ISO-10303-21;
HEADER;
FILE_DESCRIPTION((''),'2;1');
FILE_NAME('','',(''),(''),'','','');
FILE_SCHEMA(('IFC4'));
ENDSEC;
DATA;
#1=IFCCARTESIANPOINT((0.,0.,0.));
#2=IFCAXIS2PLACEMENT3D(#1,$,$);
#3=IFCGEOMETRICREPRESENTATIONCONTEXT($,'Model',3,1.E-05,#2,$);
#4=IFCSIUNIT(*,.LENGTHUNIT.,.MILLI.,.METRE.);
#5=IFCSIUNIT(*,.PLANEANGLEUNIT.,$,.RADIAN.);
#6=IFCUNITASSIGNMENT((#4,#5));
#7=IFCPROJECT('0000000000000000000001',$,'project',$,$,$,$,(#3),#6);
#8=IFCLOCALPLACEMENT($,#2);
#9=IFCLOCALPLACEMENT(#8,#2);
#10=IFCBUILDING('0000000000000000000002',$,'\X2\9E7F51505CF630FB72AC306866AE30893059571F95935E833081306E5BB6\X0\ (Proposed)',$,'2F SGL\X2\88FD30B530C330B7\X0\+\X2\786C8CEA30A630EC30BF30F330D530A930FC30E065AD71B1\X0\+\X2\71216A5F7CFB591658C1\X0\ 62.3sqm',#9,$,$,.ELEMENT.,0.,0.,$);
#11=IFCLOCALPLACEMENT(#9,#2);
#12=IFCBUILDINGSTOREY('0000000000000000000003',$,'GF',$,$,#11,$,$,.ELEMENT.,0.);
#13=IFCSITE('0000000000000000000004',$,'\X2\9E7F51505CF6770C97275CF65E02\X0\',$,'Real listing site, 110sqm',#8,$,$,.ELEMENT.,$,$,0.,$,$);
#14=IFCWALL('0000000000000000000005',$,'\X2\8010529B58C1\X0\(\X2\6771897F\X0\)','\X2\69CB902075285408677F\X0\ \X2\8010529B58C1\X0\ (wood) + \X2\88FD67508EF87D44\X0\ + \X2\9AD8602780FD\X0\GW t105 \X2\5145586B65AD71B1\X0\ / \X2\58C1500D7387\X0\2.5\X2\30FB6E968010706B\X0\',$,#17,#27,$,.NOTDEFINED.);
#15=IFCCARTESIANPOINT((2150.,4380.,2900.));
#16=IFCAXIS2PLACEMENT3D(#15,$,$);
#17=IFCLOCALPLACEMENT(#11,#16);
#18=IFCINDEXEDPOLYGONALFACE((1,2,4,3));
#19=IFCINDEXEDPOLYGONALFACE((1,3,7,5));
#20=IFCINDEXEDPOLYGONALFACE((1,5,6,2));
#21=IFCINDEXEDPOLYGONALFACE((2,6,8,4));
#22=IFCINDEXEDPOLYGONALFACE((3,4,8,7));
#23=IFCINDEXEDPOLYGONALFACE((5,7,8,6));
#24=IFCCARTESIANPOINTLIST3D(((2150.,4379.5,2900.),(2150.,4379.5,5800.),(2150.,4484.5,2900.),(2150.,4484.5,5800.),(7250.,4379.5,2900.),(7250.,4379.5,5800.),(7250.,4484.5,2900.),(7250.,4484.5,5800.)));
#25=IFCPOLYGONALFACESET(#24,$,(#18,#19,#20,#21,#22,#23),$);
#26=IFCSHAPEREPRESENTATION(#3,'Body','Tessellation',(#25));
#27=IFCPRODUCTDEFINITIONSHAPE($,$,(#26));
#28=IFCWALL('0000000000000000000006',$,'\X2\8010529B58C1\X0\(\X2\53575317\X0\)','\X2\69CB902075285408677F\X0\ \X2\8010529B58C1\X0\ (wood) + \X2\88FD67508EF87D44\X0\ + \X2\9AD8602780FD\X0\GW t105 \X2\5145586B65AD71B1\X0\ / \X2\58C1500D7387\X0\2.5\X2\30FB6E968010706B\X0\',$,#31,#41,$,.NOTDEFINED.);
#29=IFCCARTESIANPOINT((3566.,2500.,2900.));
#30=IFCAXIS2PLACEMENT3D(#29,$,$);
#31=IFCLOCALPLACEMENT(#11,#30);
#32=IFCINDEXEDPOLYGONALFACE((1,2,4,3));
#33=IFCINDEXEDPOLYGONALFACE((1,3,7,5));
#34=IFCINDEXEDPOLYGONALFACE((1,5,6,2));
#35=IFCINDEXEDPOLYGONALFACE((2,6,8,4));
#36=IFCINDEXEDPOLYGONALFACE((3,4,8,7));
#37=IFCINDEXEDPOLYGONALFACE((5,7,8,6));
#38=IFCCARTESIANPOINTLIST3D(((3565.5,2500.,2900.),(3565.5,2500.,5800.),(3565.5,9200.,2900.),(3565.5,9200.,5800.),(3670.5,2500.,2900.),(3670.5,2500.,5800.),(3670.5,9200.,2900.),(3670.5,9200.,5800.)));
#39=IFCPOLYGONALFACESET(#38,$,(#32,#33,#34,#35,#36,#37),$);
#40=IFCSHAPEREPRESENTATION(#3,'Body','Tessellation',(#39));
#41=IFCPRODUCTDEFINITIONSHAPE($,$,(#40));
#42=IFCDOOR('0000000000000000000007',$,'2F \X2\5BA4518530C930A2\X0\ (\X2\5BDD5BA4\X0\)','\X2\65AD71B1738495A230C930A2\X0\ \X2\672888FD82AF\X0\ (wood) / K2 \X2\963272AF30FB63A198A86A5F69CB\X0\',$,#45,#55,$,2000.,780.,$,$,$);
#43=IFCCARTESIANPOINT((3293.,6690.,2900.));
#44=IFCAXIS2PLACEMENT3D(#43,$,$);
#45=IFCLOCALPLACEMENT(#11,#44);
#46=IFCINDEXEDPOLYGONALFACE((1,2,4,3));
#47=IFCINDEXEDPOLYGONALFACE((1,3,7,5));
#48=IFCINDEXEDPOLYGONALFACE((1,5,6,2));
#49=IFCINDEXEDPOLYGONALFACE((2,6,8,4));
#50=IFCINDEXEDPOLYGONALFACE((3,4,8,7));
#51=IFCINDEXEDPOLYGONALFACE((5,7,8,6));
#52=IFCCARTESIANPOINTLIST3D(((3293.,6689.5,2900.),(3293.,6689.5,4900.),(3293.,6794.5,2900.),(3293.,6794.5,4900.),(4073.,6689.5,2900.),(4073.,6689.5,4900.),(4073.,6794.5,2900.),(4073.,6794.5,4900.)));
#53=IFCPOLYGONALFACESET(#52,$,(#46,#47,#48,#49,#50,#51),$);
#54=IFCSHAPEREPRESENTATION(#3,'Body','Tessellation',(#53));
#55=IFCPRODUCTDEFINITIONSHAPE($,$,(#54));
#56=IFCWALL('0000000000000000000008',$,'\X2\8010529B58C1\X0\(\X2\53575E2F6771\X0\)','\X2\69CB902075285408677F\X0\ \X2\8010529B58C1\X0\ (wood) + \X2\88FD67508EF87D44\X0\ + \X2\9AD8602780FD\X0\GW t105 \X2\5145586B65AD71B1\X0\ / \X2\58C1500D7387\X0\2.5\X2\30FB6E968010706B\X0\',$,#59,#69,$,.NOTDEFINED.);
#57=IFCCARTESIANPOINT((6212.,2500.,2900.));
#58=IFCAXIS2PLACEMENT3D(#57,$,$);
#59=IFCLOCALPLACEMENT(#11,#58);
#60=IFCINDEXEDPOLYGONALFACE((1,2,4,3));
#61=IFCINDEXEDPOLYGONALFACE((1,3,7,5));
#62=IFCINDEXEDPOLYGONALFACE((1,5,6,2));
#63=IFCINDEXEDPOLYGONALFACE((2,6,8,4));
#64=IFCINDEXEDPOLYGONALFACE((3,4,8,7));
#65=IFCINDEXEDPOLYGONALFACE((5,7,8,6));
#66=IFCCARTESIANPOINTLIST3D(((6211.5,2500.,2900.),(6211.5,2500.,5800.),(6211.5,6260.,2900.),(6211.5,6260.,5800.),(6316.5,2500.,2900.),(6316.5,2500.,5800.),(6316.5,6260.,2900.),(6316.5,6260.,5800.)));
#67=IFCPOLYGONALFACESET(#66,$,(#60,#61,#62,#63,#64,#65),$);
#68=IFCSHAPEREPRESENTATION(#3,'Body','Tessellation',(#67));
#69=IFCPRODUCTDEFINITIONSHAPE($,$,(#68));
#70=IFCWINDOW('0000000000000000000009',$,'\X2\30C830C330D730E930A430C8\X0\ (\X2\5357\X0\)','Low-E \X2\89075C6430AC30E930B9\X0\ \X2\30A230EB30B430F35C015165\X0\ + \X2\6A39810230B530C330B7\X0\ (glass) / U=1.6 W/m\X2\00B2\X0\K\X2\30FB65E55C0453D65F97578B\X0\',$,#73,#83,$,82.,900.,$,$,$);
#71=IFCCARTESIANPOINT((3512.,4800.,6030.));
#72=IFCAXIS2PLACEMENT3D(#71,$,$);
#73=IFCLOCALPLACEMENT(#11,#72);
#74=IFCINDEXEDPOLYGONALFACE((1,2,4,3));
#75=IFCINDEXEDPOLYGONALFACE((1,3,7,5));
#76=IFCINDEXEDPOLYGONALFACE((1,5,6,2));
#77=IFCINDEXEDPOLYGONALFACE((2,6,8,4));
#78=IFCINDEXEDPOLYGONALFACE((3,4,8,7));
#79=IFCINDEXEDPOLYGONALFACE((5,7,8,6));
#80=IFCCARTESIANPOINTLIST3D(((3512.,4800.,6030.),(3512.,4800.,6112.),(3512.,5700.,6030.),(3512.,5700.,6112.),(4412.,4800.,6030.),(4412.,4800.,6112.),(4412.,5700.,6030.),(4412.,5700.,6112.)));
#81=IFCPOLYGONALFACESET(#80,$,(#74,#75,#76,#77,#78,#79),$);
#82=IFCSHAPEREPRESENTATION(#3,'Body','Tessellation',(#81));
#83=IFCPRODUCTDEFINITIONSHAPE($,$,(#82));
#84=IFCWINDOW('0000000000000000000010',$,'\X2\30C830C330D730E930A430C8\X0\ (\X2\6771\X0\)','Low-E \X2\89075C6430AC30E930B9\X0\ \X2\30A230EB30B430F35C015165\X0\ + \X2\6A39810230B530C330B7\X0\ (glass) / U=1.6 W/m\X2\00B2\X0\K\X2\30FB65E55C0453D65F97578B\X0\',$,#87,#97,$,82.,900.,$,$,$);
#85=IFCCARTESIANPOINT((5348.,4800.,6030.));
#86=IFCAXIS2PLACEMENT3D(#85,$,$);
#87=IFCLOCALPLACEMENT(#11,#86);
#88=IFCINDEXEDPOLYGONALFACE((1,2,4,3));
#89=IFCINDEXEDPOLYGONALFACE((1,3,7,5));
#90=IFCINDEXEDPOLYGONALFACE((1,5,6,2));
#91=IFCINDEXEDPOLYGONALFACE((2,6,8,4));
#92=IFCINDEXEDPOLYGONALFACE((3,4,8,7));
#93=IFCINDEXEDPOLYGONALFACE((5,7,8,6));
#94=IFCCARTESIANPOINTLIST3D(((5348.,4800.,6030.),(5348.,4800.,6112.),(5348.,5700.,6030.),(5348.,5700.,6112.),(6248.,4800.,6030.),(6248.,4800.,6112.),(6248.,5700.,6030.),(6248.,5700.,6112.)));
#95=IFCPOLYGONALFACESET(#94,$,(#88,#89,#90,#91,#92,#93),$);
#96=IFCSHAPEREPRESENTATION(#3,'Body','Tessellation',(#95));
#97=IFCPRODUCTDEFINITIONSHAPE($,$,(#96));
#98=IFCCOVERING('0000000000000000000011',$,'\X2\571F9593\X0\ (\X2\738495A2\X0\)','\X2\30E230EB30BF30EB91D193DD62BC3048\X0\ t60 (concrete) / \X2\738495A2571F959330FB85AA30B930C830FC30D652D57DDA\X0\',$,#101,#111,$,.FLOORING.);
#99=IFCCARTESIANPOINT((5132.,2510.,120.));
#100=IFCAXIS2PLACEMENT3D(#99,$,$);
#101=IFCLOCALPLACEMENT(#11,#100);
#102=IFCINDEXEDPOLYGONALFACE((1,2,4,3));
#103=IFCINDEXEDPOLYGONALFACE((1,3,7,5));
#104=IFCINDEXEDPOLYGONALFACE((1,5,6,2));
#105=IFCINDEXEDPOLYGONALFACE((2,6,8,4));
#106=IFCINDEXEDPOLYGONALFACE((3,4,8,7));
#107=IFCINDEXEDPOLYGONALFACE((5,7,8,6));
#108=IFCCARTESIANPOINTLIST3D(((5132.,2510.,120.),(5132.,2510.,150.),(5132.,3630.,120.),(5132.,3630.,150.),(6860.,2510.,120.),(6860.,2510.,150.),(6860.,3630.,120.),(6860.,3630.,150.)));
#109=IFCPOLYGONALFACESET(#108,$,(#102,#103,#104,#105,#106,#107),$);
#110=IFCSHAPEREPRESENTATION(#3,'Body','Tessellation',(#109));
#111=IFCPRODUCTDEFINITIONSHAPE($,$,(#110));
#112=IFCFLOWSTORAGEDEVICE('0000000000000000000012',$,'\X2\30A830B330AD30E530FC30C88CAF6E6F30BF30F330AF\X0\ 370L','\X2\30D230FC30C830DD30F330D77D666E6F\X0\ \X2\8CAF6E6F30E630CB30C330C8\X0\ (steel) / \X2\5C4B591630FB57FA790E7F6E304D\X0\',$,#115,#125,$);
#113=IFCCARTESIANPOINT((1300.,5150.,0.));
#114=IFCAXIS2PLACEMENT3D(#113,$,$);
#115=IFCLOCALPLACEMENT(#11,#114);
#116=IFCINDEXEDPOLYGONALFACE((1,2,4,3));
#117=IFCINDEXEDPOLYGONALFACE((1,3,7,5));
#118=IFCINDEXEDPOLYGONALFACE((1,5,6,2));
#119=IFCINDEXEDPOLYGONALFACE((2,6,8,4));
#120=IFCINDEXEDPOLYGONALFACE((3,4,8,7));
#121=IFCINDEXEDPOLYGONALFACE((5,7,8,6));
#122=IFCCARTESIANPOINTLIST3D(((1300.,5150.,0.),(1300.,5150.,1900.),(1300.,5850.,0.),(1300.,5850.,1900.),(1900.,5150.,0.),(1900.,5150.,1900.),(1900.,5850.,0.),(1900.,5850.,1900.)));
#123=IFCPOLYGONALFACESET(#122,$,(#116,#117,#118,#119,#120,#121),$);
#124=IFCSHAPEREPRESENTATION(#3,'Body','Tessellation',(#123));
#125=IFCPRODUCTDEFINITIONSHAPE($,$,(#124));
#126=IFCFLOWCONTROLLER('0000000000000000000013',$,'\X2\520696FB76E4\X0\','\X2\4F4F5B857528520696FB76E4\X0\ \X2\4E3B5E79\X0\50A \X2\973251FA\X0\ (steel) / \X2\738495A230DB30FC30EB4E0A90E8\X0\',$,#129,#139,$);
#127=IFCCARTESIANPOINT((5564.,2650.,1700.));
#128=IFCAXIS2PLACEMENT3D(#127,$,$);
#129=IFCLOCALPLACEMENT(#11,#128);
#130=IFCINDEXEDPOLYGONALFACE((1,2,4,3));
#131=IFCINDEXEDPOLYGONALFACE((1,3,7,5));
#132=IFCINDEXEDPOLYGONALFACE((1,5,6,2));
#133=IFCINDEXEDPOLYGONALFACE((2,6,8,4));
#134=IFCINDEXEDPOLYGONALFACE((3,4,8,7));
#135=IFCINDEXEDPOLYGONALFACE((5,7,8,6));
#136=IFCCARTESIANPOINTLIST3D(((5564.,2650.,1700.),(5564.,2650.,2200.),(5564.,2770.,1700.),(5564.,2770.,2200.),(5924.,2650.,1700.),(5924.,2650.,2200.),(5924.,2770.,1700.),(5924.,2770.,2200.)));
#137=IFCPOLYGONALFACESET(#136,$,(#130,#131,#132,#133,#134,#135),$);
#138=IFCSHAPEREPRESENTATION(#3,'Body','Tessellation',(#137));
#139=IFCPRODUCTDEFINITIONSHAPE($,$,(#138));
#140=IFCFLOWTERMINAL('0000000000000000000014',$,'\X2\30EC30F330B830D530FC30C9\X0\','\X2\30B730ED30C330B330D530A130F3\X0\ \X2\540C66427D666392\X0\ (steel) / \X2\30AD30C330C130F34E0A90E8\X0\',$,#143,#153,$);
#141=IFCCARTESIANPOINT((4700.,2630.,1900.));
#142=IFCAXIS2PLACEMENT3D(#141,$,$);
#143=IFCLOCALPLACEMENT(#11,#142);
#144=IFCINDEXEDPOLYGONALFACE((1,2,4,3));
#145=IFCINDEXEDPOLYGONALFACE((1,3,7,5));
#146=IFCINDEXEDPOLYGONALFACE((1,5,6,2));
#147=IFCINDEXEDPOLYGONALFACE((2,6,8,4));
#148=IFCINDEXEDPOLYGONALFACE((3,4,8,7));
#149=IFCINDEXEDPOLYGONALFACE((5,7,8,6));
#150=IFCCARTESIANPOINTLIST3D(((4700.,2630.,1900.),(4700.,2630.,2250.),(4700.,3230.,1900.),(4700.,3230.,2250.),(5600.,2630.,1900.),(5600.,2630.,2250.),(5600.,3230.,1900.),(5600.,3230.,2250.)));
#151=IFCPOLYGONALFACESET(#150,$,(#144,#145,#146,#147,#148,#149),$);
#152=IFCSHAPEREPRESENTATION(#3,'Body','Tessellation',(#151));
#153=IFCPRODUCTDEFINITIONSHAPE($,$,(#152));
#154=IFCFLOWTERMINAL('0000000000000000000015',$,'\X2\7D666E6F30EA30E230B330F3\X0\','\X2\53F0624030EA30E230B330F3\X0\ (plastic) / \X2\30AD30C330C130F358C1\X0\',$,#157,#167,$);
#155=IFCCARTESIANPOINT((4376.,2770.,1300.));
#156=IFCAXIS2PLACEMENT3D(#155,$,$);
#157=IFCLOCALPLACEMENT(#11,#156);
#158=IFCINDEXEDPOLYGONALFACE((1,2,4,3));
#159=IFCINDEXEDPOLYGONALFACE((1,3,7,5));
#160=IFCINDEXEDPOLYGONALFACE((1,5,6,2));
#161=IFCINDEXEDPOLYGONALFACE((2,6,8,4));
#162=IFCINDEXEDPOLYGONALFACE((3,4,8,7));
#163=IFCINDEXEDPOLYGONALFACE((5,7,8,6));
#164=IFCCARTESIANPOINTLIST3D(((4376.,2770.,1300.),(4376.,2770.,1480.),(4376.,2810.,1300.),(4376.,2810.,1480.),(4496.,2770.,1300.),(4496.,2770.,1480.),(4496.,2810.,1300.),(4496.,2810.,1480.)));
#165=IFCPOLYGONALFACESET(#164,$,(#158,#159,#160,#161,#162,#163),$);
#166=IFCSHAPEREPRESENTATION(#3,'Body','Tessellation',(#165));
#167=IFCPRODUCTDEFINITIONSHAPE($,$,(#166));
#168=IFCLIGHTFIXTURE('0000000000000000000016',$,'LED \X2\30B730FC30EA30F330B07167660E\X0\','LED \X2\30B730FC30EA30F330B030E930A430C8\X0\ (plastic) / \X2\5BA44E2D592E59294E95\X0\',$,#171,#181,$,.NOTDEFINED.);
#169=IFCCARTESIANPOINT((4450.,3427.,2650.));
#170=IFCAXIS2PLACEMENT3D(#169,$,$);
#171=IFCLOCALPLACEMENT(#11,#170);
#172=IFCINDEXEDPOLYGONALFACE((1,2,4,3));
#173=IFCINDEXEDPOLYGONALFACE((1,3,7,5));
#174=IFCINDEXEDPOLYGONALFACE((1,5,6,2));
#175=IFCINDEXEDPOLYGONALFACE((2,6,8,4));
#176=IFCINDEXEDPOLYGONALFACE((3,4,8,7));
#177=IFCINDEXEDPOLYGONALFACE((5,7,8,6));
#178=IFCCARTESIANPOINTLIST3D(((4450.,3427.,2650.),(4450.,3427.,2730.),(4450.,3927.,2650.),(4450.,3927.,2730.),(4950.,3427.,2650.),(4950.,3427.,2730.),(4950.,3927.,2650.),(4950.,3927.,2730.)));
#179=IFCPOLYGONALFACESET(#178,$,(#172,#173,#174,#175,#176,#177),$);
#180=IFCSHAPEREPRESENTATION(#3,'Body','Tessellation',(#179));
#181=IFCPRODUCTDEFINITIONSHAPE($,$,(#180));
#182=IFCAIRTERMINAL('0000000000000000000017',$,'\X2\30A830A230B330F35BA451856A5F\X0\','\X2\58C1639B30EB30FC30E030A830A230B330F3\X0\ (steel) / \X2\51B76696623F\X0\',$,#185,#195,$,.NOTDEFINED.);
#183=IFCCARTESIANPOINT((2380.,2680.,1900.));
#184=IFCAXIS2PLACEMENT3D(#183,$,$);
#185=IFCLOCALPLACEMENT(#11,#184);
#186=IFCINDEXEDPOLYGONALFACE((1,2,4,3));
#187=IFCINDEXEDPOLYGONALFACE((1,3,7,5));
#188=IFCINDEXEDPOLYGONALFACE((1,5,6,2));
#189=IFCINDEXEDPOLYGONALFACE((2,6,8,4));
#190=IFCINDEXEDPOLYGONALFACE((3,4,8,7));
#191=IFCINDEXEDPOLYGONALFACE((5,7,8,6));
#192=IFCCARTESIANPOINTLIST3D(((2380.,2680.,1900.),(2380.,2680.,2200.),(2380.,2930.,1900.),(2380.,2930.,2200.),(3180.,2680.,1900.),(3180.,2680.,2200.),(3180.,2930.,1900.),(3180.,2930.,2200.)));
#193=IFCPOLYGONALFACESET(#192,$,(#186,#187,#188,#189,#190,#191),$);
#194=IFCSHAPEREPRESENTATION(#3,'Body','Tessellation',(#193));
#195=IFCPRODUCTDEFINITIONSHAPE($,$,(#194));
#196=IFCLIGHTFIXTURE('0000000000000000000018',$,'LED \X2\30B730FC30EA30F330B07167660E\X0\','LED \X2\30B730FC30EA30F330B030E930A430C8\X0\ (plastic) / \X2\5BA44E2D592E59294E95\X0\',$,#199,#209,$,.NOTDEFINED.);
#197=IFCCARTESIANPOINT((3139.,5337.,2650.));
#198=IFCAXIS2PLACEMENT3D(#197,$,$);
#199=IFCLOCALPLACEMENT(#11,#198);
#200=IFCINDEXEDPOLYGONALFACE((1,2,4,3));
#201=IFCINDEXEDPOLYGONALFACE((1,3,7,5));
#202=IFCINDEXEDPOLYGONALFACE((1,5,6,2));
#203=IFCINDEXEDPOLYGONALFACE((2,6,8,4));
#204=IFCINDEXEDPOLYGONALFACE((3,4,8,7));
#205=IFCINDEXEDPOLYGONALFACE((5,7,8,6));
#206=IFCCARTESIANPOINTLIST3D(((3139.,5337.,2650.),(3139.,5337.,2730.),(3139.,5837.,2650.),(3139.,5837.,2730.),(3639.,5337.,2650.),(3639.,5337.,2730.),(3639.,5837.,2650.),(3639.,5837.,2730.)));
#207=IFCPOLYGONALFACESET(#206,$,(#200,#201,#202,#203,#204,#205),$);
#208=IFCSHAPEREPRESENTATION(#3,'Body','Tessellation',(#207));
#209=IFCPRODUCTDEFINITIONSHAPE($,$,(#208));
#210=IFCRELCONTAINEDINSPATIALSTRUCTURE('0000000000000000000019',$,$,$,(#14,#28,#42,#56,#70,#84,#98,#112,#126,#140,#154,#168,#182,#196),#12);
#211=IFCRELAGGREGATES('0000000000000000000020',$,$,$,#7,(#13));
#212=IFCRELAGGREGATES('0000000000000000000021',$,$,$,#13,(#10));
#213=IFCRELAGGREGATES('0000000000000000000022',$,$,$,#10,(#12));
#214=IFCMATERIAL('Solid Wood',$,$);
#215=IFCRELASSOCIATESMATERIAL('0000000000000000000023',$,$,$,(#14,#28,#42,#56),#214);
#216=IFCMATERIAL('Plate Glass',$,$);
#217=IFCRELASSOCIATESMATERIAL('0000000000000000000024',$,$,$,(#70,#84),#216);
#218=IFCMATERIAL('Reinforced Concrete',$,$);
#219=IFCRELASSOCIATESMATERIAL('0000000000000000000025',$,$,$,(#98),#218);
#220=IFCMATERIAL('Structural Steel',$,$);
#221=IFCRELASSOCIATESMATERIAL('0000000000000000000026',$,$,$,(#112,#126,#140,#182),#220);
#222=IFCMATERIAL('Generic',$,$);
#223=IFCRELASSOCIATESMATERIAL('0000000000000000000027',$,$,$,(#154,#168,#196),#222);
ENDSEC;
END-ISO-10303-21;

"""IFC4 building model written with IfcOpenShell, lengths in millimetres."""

from ifc_helpers import new_model, si_unit, frame, frame_2d, origin, place, context, project, spatial, rectangle, extrude, material, element, fill, save


model = new_model("IFC4")

# Units and contexts
model_context = context("Model", 3, precision=1e-05, world=origin())
ifc_project = project(units=[si_unit("LENGTHUNIT", "METRE", prefix="MILLI"), si_unit("PLANEANGLEUNIT", "RADIAN")], contexts=[model_context])

# Site, building, storey
site_placement = place(None, origin())
site = spatial("IfcSite", under=ifc_project, at=site_placement, Name="鹿児島県霧島市", ObjectType="Real listing site, 110sqm", CompositionType="ELEMENT", RefElevation=0.0)
building_placement = place(site_placement, origin())
building = spatial("IfcBuilding", under=site, at=building_placement, Name="鹿児島・犬と暮らす土間広めの家 (Proposed)", ObjectType="2F SGL製サッシ+硬質ウレタンフォーム断熱+無機系外壁 62.3sqm", CompositionType="ELEMENT", ElevationOfRefHeight=0.0, ElevationOfTerrain=0.0)
storey_placement = place(building_placement, origin())
storey = spatial("IfcBuildingStorey", under=building, at=storey_placement, Name="GF", CompositionType="ELEMENT", Elevation=0.0)

# Shared definitions
ifc_material_1 = material(Name="Solid Wood")

# Wall
wall_1_placement = place(storey_placement, frame((2150.0, 4380.0, 2900.0)))
element("IfcWall", 1, at=wall_1_placement, inside=storey, material=ifc_material_1, Name="耐力壁(東西)", Description="構造用合板 耐力壁 (wood) + 製材軸組 + 高性能GW t105 充填断熱 / 壁倍率2.5・準耐火", PredefinedType="NOTDEFINED", context=model_context, shape_type="SweptSolid", body=[
    extrude(rectangle(XDim=5100.0, YDim=105.0, at=frame_2d((2550.0, 52.0))), frame((2150.0, 4380.0, 2900.0)), (0.0, 0.0, 1.0), 2900.0),
])

# Wall, opening, door
wall_2_placement = place(storey_placement, frame((3566.0, 2500.0, 2900.0)))
wall_2 = element("IfcWall", 2, at=wall_2_placement, inside=storey, material=ifc_material_1, Name="耐力壁(南北)", Description="構造用合板 耐力壁 (wood) + 製材軸組 + 高性能GW t105 充填断熱 / 壁倍率2.5・準耐火", PredefinedType="NOTDEFINED", context=model_context, shape_type="SweptSolid", body=[
    extrude(rectangle(XDim=105.0, YDim=6700.0, at=frame_2d((52.0, 3350.0))), frame((3566.0, 2500.0, 2900.0)), (0.0, 0.0, 1.0), 2900.0),
])
opening_placement = place(storey_placement, frame((3293.0, 6690.0, 2900.0)))
opening = element("IfcOpeningElement", 3, at=opening_placement, cuts=wall_2, PredefinedType="NOTDEFINED", context=model_context, shape_type="SweptSolid", body=[
    extrude(rectangle(XDim=780.0, YDim=105.0, at=frame_2d((390.0, 52.0))), frame((3293.0, 6690.0, 2900.0)), (0.0, 0.0, 1.0), 2000.0),
])
door_placement = place(storey_placement, frame((3293.0, 6690.0, 2900.0)))
door = element("IfcDoor", 4, at=door_placement, inside=storey, material=ifc_material_1, Name="2F 室内ドア (寝室)", Description="断熱玄関ドア 木製芯 (wood) / K2 防犯・採風機構", OverallHeight=2000.0, OverallWidth=780.0, context=model_context, shape_type="SweptSolid", body=[
    extrude(rectangle(XDim=780.0, YDim=105.0, at=frame_2d((390.0, 52.0))), frame((3293.0, 6690.0, 2900.0)), (0.0, 0.0, 1.0), 2000.0),
])
fill(opening, door)

# Wall
wall_3_placement = place(storey_placement, frame((6212.0, 2500.0, 2900.0)))
element("IfcWall", 5, at=wall_3_placement, inside=storey, material=ifc_material_1, Name="耐力壁(南帯東)", Description="構造用合板 耐力壁 (wood) + 製材軸組 + 高性能GW t105 充填断熱 / 壁倍率2.5・準耐火", PredefinedType="NOTDEFINED", context=model_context, shape_type="SweptSolid", body=[
    extrude(rectangle(XDim=105.0, YDim=3760.0, at=frame_2d((52.0, 1880.0))), frame((6212.0, 2500.0, 2900.0)), (0.0, 0.0, 1.0), 2900.0),
])

# Windows
ifc_material_2 = material(Name="Plate Glass")
window_1_placement = place(storey_placement, frame((3512.0, 4800.0, 6030.0)))
element("IfcWindow", 6, at=window_1_placement, inside=storey, material=ifc_material_2, Name="トップライト (南)", Description="Low-E 複層ガラス アルゴン封入 + 樹脂サッシ (glass) / U=1.6 W/m²K・日射取得型", OverallHeight=82.0, OverallWidth=900.0, context=model_context, shape_type="SweptSolid", body=[
    extrude(rectangle(XDim=900.0, YDim=900.0, at=frame_2d((450.0, 450.0))), frame((3512.0, 4800.0, 6030.0)), (0.0, 0.0, 1.0), 82.0),
])
window_2_placement = place(storey_placement, frame((5348.0, 4800.0, 6030.0)))
element("IfcWindow", 7, at=window_2_placement, inside=storey, material=ifc_material_2, Name="トップライト (東)", Description="Low-E 複層ガラス アルゴン封入 + 樹脂サッシ (glass) / U=1.6 W/m²K・日射取得型", OverallHeight=82.0, OverallWidth=900.0, context=model_context, shape_type="SweptSolid", body=[
    extrude(rectangle(XDim=900.0, YDim=900.0, at=frame_2d((450.0, 450.0))), frame((5348.0, 4800.0, 6030.0)), (0.0, 0.0, 1.0), 82.0),
])

# Covering
ifc_material_3 = material(Name="Reinforced Concrete")
covering_placement = place(storey_placement, frame((5132.0, 2510.0, 120.0)))
element("IfcCovering", 8, at=covering_placement, inside=storey, material=ifc_material_3, Name="土間 (玄関)", Description="モルタル金鏝押え t60 (concrete) / 玄関土間・薪ストーブ動線", PredefinedType="FLOORING", context=model_context, shape_type="SweptSolid", body=[
    extrude(rectangle(XDim=1728.0, YDim=1120.0, at=frame_2d((864.0, 560.0))), frame((5132.0, 2510.0, 120.0)), (0.0, 0.0, 1.0), 30.0),
])

# Flow storage device
ifc_material_4 = material(Name="Structural Steel")
flow_storage_device_placement = place(storey_placement, frame((1300.0, 5150.0, 0.0)))
element("IfcFlowStorageDevice", 9, at=flow_storage_device_placement, inside=storey, material=ifc_material_4, Name="エコキュート貯湯タンク 370L", Description="ヒートポンプ給湯 貯湯ユニット (steel) / 屋外・基礎置き", context=model_context, shape_type="SweptSolid", body=[
    extrude(rectangle(XDim=600.0, YDim=700.0, at=frame_2d((300.0, 350.0))), frame((1300.0, 5150.0, 0.0)), (0.0, 0.0, 1.0), 1900.0),
])

# Flow controller
flow_controller_placement = place(storey_placement, frame((5564.0, 2650.0, 1700.0)))
element("IfcFlowController", 10, at=flow_controller_placement, inside=storey, material=ifc_material_4, Name="分電盤", Description="住宅用分電盤 主幹50A 露出 (steel) / 玄関ホール上部", context=model_context, shape_type="SweptSolid", body=[
    extrude(rectangle(XDim=360.0, YDim=120.0, at=frame_2d((180.0, 60.0))), frame((5564.0, 2650.0, 1700.0)), (0.0, 0.0, 1.0), 500.0),
])

# Flow terminals
flow_terminal_1_placement = place(storey_placement, frame((4700.0, 2630.0, 1900.0)))
element("IfcFlowTerminal", 11, at=flow_terminal_1_placement, inside=storey, material=ifc_material_4, Name="レンジフード", Description="シロッコファン 同時給排 (steel) / キッチン上部", context=model_context, shape_type="SweptSolid", body=[
    extrude(rectangle(XDim=900.0, YDim=600.0, at=frame_2d((450.0, 300.0))), frame((4700.0, 2630.0, 1900.0)), (0.0, 0.0, 1.0), 350.0),
])
ifc_material_5 = material(Name="Generic")
flow_terminal_2_placement = place(storey_placement, frame((4376.0, 2770.0, 1300.0)))
element("IfcFlowTerminal", 12, at=flow_terminal_2_placement, inside=storey, material=ifc_material_5, Name="給湯リモコン", Description="台所リモコン (plastic) / キッチン壁", context=model_context, shape_type="SweptSolid", body=[
    extrude(rectangle(XDim=120.0, YDim=40.0, at=frame_2d((60.0, 20.0))), frame((4376.0, 2770.0, 1300.0)), (0.0, 0.0, 1.0), 180.0),
])

# Light fixture
light_fixture_1_placement = place(storey_placement, frame((4450.0, 3427.0, 2650.0)))
element("IfcLightFixture", 13, at=light_fixture_1_placement, inside=storey, material=ifc_material_5, Name="LED シーリング照明", Description="LED シーリングライト (plastic) / 室中央天井", PredefinedType="NOTDEFINED", context=model_context, shape_type="SweptSolid", body=[
    extrude(rectangle(XDim=500.0, YDim=500.0, at=frame_2d((250.0, 250.0))), frame((4450.0, 3427.0, 2650.0)), (0.0, 0.0, 1.0), 80.0),
])

# Air terminal
air_terminal_1_placement = place(storey_placement, frame((2380.0, 2680.0, 1900.0)))
element("IfcAirTerminal", 14, at=air_terminal_1_placement, inside=storey, material=ifc_material_4, Name="エアコン室内機", Description="壁掛ルームエアコン (steel) / 冷暖房", PredefinedType="NOTDEFINED", context=model_context, shape_type="SweptSolid", body=[
    extrude(rectangle(XDim=800.0, YDim=250.0, at=frame_2d((400.0, 125.0))), frame((2380.0, 2680.0, 1900.0)), (0.0, 0.0, 1.0), 300.0),
])

# Light fixture
light_fixture_2_placement = place(storey_placement, frame((3139.0, 5337.0, 2650.0)))
element("IfcLightFixture", 15, at=light_fixture_2_placement, inside=storey, material=ifc_material_5, Name="LED シーリング照明", Description="LED シーリングライト (plastic) / 室中央天井", PredefinedType="NOTDEFINED", context=model_context, shape_type="SweptSolid", body=[
    extrude(rectangle(XDim=500.0, YDim=500.0, at=frame_2d((250.0, 250.0))), frame((3139.0, 5337.0, 2650.0)), (0.0, 0.0, 1.0), 80.0),
])

save(model, "model.ifc")
